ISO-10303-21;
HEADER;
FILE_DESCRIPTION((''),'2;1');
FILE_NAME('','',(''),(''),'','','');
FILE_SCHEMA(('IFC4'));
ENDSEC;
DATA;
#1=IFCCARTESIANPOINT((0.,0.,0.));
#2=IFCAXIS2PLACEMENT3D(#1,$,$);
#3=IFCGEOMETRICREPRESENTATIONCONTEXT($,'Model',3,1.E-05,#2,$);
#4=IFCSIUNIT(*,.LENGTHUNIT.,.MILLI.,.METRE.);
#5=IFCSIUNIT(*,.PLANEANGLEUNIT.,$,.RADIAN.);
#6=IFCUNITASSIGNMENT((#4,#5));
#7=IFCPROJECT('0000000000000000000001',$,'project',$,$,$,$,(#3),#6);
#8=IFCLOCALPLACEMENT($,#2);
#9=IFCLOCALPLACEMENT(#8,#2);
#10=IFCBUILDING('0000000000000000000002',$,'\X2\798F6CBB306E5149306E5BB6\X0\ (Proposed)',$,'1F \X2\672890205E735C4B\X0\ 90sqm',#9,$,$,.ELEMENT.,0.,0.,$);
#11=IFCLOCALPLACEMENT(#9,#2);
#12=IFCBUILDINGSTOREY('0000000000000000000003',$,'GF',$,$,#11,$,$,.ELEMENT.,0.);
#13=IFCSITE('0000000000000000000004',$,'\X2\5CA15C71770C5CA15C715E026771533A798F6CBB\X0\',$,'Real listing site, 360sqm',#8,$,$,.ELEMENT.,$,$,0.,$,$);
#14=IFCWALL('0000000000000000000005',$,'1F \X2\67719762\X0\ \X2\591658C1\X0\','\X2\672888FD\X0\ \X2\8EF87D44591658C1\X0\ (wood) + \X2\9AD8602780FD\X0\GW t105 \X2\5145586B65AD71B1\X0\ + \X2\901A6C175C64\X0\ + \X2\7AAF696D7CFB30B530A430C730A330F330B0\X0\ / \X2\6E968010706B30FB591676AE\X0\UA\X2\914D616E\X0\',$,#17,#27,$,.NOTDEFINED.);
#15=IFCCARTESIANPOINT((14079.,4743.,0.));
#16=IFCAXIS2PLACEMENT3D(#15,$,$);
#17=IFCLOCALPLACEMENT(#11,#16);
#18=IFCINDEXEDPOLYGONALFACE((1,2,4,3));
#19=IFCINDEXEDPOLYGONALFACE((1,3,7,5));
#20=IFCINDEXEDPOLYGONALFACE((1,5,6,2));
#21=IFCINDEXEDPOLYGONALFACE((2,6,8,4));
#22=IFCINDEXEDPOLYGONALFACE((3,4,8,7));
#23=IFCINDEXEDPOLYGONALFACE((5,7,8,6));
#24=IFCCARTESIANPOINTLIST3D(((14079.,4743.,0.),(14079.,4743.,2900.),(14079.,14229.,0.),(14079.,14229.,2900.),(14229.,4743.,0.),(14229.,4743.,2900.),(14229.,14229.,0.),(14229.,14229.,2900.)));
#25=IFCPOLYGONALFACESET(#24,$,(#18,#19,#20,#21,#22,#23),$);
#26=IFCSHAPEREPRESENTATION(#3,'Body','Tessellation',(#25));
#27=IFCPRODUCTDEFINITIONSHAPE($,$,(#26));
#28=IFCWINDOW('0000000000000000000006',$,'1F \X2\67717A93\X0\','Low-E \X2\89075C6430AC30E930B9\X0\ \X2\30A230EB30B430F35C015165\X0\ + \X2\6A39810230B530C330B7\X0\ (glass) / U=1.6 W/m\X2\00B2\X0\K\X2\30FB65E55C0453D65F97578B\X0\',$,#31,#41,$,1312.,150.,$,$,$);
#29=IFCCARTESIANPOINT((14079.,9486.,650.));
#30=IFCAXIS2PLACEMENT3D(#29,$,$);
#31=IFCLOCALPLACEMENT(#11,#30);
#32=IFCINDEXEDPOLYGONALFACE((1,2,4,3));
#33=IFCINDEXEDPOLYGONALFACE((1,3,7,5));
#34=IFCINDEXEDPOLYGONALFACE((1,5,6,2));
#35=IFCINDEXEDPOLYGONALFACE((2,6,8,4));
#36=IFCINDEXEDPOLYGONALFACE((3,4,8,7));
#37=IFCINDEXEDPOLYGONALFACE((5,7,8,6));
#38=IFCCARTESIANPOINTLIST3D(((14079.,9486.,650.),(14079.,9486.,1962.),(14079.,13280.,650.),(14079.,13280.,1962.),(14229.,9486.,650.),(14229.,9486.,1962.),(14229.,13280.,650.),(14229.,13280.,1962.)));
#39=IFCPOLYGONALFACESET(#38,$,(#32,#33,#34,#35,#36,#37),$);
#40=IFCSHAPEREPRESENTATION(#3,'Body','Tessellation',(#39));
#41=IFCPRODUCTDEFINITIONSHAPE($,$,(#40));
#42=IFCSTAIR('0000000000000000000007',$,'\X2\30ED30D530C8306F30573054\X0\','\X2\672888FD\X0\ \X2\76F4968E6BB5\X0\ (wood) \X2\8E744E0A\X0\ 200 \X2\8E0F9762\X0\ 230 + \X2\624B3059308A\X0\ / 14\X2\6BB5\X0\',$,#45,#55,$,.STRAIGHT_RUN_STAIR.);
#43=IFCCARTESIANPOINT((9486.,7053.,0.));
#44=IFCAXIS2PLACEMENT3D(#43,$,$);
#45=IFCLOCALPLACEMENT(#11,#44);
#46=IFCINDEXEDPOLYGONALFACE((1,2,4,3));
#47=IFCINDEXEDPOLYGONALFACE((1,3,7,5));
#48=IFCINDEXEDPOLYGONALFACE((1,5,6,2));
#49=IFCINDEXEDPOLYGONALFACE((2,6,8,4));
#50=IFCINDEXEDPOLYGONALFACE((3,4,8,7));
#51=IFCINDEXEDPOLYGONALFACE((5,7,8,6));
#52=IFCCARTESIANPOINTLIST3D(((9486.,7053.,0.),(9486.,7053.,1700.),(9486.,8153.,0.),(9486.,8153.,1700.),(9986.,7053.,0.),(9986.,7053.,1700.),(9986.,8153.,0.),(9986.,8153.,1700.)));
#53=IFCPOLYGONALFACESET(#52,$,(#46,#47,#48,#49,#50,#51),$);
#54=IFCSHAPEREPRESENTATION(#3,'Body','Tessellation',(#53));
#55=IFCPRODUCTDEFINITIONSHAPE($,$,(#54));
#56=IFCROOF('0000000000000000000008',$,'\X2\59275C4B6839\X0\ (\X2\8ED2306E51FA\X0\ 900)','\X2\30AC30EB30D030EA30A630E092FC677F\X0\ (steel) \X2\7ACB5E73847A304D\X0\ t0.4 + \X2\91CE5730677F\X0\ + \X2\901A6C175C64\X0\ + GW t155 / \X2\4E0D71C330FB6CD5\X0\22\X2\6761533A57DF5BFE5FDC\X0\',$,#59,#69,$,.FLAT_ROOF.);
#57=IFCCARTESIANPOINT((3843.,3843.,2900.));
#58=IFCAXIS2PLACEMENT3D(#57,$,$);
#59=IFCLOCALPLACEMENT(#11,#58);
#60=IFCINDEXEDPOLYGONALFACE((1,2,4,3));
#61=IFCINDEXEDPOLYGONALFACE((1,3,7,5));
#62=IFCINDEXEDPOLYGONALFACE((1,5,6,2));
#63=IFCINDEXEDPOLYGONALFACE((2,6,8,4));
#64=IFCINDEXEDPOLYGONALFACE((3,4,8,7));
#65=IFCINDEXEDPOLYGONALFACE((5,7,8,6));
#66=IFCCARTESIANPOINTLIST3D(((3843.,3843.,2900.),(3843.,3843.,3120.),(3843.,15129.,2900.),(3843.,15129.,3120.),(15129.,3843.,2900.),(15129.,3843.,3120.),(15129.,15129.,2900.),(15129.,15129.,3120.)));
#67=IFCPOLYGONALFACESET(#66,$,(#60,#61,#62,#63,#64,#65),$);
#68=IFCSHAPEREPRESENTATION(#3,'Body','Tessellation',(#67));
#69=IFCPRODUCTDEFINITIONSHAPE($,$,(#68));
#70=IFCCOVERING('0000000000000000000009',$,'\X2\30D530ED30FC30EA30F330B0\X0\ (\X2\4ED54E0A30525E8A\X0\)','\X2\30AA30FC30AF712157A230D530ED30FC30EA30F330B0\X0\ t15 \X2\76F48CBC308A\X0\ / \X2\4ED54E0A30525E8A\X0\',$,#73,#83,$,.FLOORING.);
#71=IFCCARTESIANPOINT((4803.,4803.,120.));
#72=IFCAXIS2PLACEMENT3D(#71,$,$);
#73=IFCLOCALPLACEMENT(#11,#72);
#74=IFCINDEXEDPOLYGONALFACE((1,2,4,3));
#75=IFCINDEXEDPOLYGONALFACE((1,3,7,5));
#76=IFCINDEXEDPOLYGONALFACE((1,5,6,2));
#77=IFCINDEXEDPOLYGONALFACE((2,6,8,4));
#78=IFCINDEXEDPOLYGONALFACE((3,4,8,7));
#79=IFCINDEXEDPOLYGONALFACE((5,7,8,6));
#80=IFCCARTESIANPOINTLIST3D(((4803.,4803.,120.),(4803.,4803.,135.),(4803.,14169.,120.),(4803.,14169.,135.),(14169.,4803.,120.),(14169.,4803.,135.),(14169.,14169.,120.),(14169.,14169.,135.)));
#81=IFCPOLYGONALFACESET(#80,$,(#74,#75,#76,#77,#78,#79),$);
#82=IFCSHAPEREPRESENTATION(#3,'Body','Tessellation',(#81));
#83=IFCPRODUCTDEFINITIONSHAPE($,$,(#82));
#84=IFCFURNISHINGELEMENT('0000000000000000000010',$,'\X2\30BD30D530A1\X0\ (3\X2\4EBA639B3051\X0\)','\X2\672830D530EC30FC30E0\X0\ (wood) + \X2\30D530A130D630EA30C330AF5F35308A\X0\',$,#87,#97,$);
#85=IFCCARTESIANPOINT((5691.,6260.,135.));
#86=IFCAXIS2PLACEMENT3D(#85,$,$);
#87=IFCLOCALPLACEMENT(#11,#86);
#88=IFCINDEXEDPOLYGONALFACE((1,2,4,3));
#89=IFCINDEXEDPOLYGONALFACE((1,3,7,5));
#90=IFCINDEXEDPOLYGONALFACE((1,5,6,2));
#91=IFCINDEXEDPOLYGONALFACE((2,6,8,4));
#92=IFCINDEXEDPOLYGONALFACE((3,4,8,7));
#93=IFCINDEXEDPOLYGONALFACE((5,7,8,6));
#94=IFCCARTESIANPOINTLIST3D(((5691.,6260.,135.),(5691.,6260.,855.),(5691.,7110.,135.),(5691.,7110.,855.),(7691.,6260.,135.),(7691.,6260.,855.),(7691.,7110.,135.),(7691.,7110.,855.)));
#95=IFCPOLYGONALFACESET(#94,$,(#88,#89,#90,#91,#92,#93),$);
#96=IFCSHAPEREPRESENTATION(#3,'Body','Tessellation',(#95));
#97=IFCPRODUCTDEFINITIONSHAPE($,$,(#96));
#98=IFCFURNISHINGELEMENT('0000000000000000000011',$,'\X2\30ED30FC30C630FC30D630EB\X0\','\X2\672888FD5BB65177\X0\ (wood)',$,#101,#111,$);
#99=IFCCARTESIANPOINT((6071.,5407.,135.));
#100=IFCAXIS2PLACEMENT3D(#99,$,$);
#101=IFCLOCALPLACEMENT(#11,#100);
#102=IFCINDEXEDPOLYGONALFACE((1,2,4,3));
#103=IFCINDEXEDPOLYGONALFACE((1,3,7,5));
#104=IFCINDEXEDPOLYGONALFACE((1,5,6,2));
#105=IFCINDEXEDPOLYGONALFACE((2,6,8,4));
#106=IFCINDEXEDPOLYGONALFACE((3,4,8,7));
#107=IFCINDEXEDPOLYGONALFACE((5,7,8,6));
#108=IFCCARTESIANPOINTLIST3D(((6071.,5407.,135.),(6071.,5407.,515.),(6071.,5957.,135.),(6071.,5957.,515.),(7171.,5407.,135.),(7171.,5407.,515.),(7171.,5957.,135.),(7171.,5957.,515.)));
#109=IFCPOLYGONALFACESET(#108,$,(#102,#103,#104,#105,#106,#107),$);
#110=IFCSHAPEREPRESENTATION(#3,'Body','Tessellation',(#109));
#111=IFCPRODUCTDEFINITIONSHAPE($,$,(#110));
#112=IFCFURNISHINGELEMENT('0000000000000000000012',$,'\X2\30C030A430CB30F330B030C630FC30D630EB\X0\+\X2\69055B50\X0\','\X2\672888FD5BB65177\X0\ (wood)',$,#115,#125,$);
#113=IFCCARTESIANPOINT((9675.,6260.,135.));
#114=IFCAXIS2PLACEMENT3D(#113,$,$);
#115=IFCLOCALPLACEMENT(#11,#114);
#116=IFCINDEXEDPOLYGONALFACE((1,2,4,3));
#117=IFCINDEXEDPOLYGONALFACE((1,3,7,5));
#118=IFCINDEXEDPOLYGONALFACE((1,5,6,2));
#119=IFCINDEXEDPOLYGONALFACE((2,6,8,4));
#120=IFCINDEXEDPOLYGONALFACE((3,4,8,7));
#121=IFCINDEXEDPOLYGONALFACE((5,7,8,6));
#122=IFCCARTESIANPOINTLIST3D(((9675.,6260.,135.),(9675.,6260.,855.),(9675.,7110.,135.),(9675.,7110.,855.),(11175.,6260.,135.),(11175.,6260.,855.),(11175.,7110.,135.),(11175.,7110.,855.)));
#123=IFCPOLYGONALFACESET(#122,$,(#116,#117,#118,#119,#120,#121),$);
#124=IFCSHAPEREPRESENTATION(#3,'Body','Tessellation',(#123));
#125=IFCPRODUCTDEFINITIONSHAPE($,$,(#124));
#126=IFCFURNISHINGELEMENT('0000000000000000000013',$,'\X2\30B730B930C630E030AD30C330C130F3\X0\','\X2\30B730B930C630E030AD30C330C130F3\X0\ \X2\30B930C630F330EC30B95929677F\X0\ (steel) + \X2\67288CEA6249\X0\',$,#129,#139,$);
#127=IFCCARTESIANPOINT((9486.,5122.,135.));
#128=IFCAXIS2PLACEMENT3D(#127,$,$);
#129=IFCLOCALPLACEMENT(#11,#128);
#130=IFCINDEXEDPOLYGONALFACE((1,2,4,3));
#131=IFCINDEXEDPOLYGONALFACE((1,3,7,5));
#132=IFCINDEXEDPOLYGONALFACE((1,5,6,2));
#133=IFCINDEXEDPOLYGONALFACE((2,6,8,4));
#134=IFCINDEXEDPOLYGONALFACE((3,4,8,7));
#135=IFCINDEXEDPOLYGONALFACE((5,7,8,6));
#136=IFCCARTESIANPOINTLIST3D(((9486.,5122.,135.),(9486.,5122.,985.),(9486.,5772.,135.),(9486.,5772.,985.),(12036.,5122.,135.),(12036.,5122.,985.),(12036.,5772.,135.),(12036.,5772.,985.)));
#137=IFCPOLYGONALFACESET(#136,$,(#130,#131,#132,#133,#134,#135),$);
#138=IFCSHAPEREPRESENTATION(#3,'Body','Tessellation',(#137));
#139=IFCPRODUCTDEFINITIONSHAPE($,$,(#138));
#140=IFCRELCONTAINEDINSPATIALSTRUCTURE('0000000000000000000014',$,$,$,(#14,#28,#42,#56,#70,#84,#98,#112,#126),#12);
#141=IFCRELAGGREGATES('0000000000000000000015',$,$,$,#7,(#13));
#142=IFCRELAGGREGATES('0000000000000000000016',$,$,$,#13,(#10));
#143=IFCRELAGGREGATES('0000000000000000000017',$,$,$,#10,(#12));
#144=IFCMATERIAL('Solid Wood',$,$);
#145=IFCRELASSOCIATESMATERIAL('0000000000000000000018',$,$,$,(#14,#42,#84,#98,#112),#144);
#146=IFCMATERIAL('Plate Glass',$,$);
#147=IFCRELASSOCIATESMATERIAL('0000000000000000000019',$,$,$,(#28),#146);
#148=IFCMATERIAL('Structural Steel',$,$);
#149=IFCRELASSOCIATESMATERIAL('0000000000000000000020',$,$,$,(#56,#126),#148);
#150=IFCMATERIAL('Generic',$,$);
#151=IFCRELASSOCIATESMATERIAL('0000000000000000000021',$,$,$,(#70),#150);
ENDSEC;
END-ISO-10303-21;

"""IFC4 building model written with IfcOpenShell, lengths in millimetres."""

from ifc_helpers import new_model, si_unit, frame, frame_2d, origin, place, context, project, spatial, rectangle, extrude, material, element, fill, save


model = new_model("IFC4")

# Units and contexts
model_context = context("Model", 3, precision=1e-05, world=origin())
ifc_project = project(units=[si_unit("LENGTHUNIT", "METRE", prefix="MILLI"), si_unit("PLANEANGLEUNIT", "RADIAN")], contexts=[model_context])

# Site, building, storey
site_placement = place(None, origin())
site = spatial("IfcSite", under=ifc_project, at=site_placement, Name="岡山県岡山市東区福治", ObjectType="Real listing site, 360sqm", CompositionType="ELEMENT", RefElevation=0.0)
building_placement = place(site_placement, origin())
building = spatial("IfcBuilding", under=site, at=building_placement, Name="福治の光の家 (Proposed)", ObjectType="1F 木造平屋 90sqm", CompositionType="ELEMENT", ElevationOfRefHeight=0.0, ElevationOfTerrain=0.0)
storey_placement = place(building_placement, origin())
storey = spatial("IfcBuildingStorey", under=building, at=storey_placement, Name="GF", CompositionType="ELEMENT", Elevation=0.0)

# Shared definitions
ifc_material_1 = material(Name="Solid Wood")

# Shared definitions
ifc_material_2 = material(Name="Plate Glass")

# Wall, opening, window
wall_1_placement = place(storey_placement, frame((14079.0, 4743.0, 0.0)))
wall_1 = element("IfcWall", 1, at=wall_1_placement, inside=storey, material=ifc_material_1, Name="1F 東面 外壁", Description="木製 軸組外壁 (wood) + 高性能GW t105 充填断熱 + 通気層 + 窯業系サイディング / 準耐火・外皮UA配慮", PredefinedType="NOTDEFINED", context=model_context, shape_type="SweptSolid", body=[
    extrude(rectangle(XDim=150.0, YDim=9486.0, at=frame_2d((75.0, 4743.0))), frame((14079.0, 4743.0, 0.0)), (0.0, 0.0, 1.0), 2900.0),
])
opening_1_placement = place(storey_placement, frame((14079.0, 9486.0, 650.0)))
opening_1 = element("IfcOpeningElement", 2, at=opening_1_placement, cuts=wall_1, PredefinedType="NOTDEFINED", context=model_context, shape_type="SweptSolid", body=[
    extrude(rectangle(XDim=150.0, YDim=3794.0, at=frame_2d((75.0, 1897.0))), frame((14079.0, 9486.0, 650.0)), (0.0, 0.0, 1.0), 1312.0),
])
window_1_placement = place(storey_placement, frame((14079.0, 9486.0, 650.0)))
window_1 = element("IfcWindow", 3, at=window_1_placement, inside=storey, material=ifc_material_2, Name="1F 東窓", Description="Low-E 複層ガラス アルゴン封入 + 樹脂サッシ (glass) / U=1.6 W/m²K・日射取得型", OverallHeight=1312.0, OverallWidth=150.0, context=model_context, shape_type="SweptSolid", body=[
    extrude(rectangle(XDim=150.0, YDim=3794.0, at=frame_2d((75.0, 1897.0))), frame((14079.0, 9486.0, 650.0)), (0.0, 0.0, 1.0), 1312.0),
])
fill(opening_1, window_1)

# Stair
stair_placement = place(storey_placement, frame((9486.0, 7053.0, 0.0)))
element("IfcStair", 4, at=stair_placement, inside=storey, material=ifc_material_1, Name="ロフトはしご", Description="木製 直階段 (wood) 蹴上 200 踏面 230 + 手すり / 14段", PredefinedType="STRAIGHT_RUN_STAIR", context=model_context, shape_type="SweptSolid", body=[
    extrude(rectangle(XDim=500.0, YDim=1100.0, at=frame_2d((250.0, 550.0))), frame((9486.0, 7053.0, 0.0)), (0.0, 0.0, 1.0), 1700.0),
])

# Roof
ifc_material_3 = material(Name="Structural Steel")
roof_placement = place(storey_placement, frame((3843.0, 3843.0, 2900.0)))
element("IfcRoof", 5, at=roof_placement, inside=storey, material=ifc_material_3, Name="大屋根 (軒の出 900)", Description="ガルバリウム鋼板 (steel) 立平葺き t0.4 + 野地板 + 通気層 + GW t155 / 不燃・法22条区域対応", PredefinedType="FLAT_ROOF", context=model_context, shape_type="SweptSolid", body=[
    extrude(rectangle(XDim=11286.0, YDim=11286.0, at=frame_2d((5643.0, 5643.0))), frame((3843.0, 3843.0, 2900.0)), (0.0, 0.0, 1.0), 220.0),
])

# Covering
ifc_material_4 = material(Name="Generic")
covering_placement = place(storey_placement, frame((4803.0, 4803.0, 120.0)))
element("IfcCovering", 6, at=covering_placement, inside=storey, material=ifc_material_4, Name="フローリング (仕上げ床)", Description="オーク無垢フローリング t15 直貼り / 仕上げ床", PredefinedType="FLOORING", context=model_context, shape_type="SweptSolid", body=[
    extrude(rectangle(XDim=9366.0, YDim=9366.0, at=frame_2d((4683.0, 4683.0))), frame((4803.0, 4803.0, 120.0)), (0.0, 0.0, 1.0), 15.0),
])

# Furnishing elements
furnishing_1_placement = place(storey_placement, frame((5691.0, 6260.0, 135.0)))
element("IfcFurnishingElement", 7, at=furnishing_1_placement, inside=storey, material=ifc_material_1, Name="ソファ (3人掛け)", Description="木フレーム (wood) + ファブリック張り", context=model_context, shape_type="SweptSolid", body=[
    extrude(rectangle(XDim=2000.0, YDim=850.0, at=frame_2d((1000.0, 425.0))), frame((5691.0, 6260.0, 135.0)), (0.0, 0.0, 1.0), 720.0),
])
furnishing_2_placement = place(storey_placement, frame((6071.0, 5407.0, 135.0)))
element("IfcFurnishingElement", 8, at=furnishing_2_placement, inside=storey, material=ifc_material_1, Name="ローテーブル", Description="木製家具 (wood)", context=model_context, shape_type="SweptSolid", body=[
    extrude(rectangle(XDim=1100.0, YDim=550.0, at=frame_2d((550.0, 275.0))), frame((6071.0, 5407.0, 135.0)), (0.0, 0.0, 1.0), 380.0),
])
furnishing_3_placement = place(storey_placement, frame((9675.0, 6260.0, 135.0)))
element("IfcFurnishingElement", 9, at=furnishing_3_placement, inside=storey, material=ifc_material_1, Name="ダイニングテーブル+椅子", Description="木製家具 (wood)", context=model_context, shape_type="SweptSolid", body=[
    extrude(rectangle(XDim=1500.0, YDim=850.0, at=frame_2d((750.0, 425.0))), frame((9675.0, 6260.0, 135.0)), (0.0, 0.0, 1.0), 720.0),
])
furnishing_4_placement = place(storey_placement, frame((9486.0, 5122.0, 135.0)))
element("IfcFurnishingElement", 10, at=furnishing_4_placement, inside=storey, material=ifc_material_3, Name="システムキッチン", Description="システムキッチン ステンレス天板 (steel) + 木質扉", context=model_context, shape_type="SweptSolid", body=[
    extrude(rectangle(XDim=2550.0, YDim=650.0, at=frame_2d((1275.0, 325.0))), frame((9486.0, 5122.0, 135.0)), (0.0, 0.0, 1.0), 850.0),
])

save(model, "model.ifc")
